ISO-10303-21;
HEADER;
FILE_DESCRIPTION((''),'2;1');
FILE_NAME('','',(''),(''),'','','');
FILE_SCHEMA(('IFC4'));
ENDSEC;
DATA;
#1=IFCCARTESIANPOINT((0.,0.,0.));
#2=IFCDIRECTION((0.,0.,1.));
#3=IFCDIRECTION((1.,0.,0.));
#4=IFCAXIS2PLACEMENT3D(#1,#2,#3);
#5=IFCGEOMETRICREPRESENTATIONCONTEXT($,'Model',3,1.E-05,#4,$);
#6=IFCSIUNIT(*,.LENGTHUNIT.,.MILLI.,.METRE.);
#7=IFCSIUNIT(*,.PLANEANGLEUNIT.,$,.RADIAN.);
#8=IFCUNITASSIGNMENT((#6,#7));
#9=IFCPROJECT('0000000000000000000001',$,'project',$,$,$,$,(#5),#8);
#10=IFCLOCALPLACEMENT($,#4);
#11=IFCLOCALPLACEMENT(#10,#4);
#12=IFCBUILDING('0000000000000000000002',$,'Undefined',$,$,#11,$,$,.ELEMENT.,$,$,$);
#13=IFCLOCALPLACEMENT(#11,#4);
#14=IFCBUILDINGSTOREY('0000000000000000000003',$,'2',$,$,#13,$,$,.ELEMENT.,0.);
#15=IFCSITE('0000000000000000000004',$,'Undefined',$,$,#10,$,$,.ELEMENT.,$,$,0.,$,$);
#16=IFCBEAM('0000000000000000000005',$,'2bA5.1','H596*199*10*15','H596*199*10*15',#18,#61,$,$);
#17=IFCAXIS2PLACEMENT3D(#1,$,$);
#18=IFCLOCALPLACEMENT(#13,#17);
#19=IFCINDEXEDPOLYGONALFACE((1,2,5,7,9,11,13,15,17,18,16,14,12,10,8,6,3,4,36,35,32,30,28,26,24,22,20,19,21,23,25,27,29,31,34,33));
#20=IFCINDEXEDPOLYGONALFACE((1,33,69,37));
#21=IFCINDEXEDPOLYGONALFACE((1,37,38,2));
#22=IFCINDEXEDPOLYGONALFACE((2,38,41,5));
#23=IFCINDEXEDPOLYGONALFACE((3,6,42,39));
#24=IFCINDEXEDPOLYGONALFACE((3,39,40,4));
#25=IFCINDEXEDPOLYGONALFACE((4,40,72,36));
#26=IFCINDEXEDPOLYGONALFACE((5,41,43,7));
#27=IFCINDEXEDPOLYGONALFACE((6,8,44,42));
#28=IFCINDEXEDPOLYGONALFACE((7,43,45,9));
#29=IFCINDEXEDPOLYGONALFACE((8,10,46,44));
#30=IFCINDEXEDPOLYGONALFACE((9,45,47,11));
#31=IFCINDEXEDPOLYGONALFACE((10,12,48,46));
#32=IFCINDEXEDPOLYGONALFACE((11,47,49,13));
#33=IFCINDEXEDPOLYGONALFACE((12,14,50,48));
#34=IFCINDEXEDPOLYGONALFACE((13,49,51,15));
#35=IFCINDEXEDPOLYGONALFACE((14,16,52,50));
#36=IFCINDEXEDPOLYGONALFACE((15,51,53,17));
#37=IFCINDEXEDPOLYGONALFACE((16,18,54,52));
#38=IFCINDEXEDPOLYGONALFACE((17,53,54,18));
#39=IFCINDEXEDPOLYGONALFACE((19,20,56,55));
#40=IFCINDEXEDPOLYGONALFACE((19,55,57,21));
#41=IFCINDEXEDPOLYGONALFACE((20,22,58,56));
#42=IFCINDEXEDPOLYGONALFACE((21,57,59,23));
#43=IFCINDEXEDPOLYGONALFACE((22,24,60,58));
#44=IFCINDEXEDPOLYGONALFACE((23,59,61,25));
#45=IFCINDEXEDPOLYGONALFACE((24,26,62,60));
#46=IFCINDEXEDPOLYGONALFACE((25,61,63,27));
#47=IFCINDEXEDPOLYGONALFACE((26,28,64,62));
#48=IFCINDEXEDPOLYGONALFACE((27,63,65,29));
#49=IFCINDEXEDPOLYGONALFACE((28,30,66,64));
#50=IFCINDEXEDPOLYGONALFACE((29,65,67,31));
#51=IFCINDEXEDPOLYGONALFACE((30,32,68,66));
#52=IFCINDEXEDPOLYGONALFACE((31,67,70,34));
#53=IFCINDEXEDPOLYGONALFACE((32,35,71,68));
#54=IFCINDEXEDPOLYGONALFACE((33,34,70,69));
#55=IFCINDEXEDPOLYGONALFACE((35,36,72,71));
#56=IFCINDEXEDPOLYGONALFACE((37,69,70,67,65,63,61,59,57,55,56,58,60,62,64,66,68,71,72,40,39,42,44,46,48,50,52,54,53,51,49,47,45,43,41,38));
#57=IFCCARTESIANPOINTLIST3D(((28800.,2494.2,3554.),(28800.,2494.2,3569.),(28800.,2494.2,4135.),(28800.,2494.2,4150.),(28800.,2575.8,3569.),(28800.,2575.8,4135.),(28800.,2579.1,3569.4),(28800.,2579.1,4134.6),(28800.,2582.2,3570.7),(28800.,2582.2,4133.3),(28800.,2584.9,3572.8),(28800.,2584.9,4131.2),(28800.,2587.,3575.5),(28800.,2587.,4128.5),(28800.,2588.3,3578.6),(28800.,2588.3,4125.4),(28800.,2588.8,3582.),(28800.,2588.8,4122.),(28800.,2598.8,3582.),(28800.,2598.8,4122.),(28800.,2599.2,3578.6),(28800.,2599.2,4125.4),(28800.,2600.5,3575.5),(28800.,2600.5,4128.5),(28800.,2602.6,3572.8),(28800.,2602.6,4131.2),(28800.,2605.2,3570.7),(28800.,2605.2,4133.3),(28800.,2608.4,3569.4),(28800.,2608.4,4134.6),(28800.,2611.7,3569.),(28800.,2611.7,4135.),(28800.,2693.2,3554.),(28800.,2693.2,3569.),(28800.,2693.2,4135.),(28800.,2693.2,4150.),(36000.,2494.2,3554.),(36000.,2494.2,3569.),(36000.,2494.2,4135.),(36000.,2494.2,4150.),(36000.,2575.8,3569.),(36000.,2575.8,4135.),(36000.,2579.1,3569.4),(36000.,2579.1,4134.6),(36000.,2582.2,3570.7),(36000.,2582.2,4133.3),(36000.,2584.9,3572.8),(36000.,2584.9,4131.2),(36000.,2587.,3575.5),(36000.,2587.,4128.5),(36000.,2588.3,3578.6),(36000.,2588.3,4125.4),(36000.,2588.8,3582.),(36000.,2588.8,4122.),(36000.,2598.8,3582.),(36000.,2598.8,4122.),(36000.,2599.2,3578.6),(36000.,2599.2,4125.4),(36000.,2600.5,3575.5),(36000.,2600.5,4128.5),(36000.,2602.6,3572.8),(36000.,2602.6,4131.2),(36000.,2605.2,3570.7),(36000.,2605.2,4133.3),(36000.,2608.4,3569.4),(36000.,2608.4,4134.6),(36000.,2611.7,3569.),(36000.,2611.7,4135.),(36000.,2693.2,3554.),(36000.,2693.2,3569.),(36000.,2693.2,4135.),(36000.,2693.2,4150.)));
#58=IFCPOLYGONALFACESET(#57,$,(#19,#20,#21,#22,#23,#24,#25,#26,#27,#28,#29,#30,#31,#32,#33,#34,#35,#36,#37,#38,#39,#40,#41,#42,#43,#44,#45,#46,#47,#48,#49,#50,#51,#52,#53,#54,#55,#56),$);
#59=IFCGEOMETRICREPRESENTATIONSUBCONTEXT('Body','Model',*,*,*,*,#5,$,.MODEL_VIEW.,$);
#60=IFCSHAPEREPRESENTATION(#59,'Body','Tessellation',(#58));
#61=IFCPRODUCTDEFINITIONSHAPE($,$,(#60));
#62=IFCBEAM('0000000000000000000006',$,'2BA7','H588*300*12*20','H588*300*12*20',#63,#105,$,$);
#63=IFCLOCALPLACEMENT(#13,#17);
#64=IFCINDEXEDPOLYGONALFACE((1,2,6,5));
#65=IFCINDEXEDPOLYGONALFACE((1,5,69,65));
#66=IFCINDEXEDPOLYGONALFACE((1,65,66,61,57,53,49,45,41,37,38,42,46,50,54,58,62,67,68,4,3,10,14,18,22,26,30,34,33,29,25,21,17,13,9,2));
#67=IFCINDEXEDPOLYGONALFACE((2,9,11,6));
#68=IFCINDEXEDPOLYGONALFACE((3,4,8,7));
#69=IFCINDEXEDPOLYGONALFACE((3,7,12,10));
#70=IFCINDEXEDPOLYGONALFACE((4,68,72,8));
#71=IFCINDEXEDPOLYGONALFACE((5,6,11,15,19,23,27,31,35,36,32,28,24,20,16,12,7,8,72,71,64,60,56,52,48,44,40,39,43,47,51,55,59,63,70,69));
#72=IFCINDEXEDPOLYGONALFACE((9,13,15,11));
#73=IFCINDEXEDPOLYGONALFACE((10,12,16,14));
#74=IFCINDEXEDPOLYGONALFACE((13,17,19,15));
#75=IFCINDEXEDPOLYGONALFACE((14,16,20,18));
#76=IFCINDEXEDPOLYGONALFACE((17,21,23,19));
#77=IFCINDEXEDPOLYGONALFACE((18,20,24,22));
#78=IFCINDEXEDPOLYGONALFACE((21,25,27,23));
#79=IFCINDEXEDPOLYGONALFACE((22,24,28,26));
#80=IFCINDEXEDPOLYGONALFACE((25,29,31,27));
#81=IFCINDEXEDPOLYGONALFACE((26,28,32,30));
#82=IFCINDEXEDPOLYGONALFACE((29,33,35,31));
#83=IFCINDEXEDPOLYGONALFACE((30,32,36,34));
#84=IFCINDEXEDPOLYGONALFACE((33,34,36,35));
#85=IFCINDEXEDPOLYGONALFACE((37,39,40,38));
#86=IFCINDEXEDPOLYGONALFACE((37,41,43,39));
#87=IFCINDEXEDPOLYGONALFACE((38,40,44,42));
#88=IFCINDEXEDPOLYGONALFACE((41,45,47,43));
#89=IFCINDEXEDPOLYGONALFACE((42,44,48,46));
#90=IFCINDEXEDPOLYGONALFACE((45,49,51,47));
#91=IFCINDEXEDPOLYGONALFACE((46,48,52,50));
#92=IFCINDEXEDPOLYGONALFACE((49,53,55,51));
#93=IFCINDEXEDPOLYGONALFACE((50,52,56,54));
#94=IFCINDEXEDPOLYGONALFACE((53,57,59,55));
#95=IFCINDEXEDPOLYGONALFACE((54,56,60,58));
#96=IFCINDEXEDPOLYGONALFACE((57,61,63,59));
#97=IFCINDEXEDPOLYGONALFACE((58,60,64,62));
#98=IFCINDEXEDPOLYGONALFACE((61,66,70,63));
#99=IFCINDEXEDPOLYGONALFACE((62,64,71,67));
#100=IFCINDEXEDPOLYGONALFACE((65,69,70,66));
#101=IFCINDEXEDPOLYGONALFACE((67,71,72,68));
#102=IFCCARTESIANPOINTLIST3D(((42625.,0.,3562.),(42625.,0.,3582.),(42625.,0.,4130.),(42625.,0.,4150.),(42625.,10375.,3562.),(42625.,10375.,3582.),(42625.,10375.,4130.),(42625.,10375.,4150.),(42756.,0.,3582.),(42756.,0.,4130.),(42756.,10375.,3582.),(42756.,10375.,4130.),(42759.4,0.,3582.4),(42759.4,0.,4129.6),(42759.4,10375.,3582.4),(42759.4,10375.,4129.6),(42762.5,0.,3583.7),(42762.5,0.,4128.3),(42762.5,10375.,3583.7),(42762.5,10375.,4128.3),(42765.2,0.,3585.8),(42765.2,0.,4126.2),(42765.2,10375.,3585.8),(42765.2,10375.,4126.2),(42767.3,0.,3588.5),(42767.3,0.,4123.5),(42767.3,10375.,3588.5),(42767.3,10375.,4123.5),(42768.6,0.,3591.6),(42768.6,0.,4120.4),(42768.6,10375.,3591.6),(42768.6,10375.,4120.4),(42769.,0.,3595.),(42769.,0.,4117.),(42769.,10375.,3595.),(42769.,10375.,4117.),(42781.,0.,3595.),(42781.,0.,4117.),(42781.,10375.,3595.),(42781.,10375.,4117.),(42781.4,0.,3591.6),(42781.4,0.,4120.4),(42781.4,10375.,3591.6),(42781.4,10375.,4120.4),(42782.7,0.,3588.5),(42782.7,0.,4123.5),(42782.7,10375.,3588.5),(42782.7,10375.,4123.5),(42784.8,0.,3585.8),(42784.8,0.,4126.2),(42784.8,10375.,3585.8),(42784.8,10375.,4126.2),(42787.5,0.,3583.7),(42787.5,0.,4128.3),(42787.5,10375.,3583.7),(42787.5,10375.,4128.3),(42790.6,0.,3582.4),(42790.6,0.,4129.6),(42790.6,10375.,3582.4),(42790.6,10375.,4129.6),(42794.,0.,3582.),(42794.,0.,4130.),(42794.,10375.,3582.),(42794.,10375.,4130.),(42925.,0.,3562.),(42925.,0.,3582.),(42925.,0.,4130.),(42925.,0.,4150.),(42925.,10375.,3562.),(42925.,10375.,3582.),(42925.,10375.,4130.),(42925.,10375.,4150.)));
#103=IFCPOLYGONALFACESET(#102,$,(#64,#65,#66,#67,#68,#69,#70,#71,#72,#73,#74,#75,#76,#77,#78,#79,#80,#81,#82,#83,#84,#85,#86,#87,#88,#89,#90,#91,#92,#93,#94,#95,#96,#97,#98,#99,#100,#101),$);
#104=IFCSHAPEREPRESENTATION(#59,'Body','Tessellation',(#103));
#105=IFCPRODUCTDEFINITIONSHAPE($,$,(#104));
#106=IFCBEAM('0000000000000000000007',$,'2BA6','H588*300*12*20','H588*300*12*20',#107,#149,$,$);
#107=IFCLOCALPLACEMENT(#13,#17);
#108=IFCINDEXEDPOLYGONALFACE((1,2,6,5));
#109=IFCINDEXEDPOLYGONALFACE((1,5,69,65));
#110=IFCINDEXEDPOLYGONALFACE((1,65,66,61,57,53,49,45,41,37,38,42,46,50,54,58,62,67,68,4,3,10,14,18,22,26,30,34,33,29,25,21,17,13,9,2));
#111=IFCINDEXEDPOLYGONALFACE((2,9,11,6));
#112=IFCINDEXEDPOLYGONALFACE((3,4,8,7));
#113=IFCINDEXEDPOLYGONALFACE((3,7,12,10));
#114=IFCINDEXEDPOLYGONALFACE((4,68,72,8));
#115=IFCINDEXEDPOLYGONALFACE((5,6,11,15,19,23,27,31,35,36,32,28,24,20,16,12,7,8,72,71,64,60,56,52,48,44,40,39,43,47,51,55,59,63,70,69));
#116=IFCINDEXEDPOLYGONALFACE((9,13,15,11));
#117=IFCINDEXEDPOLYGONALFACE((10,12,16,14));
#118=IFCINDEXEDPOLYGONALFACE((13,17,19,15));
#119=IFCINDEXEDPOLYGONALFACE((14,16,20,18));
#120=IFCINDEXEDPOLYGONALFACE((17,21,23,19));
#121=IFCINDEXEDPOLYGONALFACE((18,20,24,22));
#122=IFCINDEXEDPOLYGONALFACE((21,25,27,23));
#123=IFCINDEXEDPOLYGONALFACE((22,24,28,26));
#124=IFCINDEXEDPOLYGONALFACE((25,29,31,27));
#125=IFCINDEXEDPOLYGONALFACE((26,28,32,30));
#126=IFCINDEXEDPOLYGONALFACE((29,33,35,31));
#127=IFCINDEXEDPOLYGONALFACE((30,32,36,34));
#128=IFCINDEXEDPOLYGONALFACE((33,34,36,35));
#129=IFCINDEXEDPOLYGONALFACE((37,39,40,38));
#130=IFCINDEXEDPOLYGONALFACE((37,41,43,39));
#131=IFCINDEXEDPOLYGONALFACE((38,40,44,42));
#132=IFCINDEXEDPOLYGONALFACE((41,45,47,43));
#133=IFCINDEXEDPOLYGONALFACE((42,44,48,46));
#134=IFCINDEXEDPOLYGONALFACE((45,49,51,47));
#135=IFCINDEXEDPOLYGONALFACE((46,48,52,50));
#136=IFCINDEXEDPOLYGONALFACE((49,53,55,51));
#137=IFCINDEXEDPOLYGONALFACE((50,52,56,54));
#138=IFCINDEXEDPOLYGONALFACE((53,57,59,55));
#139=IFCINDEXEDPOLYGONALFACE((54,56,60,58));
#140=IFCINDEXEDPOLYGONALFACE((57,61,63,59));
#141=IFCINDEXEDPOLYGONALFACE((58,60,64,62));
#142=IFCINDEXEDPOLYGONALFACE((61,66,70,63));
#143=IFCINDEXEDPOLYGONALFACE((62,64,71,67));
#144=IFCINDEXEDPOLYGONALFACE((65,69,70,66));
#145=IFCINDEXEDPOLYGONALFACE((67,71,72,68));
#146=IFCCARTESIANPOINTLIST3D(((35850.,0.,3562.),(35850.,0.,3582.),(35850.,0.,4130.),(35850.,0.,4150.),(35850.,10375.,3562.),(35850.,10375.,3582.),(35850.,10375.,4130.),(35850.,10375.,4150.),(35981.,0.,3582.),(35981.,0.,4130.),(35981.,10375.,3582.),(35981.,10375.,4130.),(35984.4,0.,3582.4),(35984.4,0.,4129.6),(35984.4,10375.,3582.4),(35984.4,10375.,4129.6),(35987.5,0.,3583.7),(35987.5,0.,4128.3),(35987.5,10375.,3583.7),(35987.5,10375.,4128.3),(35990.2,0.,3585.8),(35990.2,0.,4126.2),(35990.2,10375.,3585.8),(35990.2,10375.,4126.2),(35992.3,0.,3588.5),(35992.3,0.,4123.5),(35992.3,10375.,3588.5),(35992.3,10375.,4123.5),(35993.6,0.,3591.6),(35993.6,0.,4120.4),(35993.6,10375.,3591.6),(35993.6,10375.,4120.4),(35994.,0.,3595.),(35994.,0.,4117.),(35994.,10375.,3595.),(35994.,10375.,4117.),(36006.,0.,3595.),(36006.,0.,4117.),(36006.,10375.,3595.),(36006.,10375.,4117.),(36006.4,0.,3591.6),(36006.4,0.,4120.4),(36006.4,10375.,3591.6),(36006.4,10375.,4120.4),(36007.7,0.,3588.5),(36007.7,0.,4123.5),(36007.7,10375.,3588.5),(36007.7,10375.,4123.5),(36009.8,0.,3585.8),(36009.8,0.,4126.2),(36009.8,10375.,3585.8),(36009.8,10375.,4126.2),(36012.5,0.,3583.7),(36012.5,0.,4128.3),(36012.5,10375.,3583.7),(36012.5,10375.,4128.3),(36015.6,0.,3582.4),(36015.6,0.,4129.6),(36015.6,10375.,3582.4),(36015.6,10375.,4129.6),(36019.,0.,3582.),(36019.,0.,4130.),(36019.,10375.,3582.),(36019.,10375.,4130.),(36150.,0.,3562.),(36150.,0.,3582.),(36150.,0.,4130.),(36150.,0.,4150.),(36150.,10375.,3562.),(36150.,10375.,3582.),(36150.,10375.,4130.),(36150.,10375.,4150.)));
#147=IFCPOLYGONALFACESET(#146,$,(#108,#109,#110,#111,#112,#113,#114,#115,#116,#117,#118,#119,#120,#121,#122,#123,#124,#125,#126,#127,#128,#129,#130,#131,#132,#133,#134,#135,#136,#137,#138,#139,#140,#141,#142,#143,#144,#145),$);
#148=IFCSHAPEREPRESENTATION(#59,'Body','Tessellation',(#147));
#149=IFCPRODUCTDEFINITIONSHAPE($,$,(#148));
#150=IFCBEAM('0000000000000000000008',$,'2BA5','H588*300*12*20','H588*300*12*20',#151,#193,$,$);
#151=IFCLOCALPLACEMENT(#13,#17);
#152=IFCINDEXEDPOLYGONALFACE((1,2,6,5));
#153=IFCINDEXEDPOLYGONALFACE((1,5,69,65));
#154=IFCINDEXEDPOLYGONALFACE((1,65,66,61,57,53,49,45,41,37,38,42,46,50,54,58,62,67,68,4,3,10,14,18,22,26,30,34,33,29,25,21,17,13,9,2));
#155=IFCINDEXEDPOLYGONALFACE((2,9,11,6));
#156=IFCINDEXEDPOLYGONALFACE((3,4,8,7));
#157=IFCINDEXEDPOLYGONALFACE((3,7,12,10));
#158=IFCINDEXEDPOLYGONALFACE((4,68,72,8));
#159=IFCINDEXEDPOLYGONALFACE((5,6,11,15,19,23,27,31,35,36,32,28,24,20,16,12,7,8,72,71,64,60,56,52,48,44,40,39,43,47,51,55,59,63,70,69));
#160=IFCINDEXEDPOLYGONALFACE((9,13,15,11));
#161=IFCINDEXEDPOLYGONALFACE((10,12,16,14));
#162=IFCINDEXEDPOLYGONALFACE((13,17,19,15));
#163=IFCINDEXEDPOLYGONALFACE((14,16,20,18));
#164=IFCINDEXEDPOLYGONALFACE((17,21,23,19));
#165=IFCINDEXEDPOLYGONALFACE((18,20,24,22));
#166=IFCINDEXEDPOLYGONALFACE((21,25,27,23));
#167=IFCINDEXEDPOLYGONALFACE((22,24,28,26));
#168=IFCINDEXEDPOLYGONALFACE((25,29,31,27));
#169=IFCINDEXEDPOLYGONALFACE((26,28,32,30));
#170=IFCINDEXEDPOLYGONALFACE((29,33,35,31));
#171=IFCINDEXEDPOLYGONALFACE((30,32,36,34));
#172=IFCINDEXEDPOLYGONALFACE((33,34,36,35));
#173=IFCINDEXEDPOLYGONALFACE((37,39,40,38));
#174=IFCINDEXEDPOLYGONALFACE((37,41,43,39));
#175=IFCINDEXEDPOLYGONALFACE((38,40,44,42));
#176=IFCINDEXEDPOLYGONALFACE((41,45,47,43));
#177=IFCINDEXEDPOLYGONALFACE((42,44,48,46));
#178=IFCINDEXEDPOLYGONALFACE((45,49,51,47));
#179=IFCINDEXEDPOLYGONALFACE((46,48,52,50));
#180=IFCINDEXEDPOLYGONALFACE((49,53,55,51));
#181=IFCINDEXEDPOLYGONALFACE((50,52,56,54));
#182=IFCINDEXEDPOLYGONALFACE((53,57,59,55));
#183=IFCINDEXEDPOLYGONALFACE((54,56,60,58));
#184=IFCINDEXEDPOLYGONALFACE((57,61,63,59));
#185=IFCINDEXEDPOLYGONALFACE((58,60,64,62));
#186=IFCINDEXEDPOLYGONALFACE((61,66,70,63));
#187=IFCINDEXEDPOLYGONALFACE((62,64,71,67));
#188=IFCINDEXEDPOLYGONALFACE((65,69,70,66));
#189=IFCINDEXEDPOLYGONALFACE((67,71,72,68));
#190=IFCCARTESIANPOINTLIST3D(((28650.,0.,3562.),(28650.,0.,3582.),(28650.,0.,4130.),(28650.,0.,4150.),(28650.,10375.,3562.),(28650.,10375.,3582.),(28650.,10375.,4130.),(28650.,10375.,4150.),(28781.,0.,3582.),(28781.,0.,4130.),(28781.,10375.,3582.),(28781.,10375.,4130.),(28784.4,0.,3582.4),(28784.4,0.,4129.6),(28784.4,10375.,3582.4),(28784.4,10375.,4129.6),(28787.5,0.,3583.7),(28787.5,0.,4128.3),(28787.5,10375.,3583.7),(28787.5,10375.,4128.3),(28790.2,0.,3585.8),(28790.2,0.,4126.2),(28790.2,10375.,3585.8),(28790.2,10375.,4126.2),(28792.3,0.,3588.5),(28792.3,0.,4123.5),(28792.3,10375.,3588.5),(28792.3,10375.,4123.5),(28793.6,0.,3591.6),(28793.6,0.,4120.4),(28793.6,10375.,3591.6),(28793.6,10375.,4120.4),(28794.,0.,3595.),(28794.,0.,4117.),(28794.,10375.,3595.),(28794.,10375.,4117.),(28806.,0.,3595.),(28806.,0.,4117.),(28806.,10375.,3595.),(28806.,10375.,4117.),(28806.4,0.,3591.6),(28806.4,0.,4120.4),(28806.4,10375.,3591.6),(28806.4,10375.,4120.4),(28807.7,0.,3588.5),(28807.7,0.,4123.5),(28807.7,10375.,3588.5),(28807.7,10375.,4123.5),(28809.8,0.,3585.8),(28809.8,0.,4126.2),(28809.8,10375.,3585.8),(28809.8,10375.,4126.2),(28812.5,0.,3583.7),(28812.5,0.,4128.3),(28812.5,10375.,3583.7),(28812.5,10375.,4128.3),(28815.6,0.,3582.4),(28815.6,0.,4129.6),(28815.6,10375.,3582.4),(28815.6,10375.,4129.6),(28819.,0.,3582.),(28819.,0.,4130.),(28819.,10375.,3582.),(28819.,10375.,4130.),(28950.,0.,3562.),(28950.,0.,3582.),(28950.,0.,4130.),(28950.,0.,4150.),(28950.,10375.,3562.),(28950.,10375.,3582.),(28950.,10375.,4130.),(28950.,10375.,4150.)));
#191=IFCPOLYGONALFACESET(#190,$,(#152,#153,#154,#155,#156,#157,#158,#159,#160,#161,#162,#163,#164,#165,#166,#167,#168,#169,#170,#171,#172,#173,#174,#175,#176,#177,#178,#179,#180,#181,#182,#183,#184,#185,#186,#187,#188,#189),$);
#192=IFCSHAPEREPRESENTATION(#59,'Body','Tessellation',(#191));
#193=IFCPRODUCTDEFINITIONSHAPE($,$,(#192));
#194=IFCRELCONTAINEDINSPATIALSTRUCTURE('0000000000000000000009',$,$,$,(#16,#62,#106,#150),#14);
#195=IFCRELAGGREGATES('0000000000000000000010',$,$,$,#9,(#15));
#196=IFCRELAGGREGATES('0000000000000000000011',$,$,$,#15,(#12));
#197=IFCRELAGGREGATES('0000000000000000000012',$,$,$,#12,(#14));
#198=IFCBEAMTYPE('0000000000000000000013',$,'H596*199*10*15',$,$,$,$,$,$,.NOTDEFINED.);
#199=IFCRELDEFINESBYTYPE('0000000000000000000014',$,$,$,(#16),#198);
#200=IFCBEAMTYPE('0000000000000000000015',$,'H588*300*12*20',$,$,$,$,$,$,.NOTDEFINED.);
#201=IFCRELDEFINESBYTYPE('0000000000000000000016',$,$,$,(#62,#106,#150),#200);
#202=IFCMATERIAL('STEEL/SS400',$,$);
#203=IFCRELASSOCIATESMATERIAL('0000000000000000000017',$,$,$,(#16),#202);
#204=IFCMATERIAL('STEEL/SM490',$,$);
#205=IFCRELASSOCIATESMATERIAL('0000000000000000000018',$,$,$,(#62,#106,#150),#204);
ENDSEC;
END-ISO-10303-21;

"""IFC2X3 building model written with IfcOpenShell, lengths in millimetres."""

from ifc_helpers import new_model, si_unit, frame, origin_with_axes, origin_2d_with_axis, place, context, subcontext, project, spatial, i_section, extrude, material, type_object, element, save


model = new_model("IFC2X3")

# Units and contexts
model_context = context("Model", 3, precision=1e-05, world=origin_with_axes())
body_context = subcontext(model_context, "Body", "Model", "MODEL_VIEW")
ifc_project = project(units=[si_unit("LENGTHUNIT", "METRE", prefix="MILLI"), si_unit("PLANEANGLEUNIT", "RADIAN")], contexts=[model_context])

# Site, building, storey
site_placement = place(None, origin_with_axes())
site = spatial("IfcSite", under=ifc_project, at=site_placement, Name="Undefined", CompositionType="ELEMENT", RefElevation=0.0)
building_placement = place(site_placement, origin_with_axes())
building = spatial("IfcBuilding", under=site, at=building_placement, Name="Undefined", CompositionType="ELEMENT")
storey_placement = place(building_placement, origin_with_axes())
storey = spatial("IfcBuildingStorey", under=building, at=storey_placement, Name="2", CompositionType="ELEMENT", Elevation=0.0)

# Beams
ifc_material_1 = material(Name="STEEL/SS400")
beam_type_1 = type_object("IfcBeamType", Name="H596*199*10*15", PredefinedType="NOTDEFINED")
for number, where, z_axis, x_axis, name in (
    (1, (28800.0, 2593.8, 3852.0), (0.0, 0.0, 1.0), (1.0, 0.0, 0.0), "2bA5.1"),
):
    element("IfcBeam", number, at=place(storey_placement, frame(where, z_axis=z_axis, x_axis=x_axis)), inside=storey, type_object=beam_type_1, material=ifc_material_1, Name=name, Description="H596*199*10*15", ObjectType="H596*199*10*15", context=body_context, shape_type="SweptSolid", body=[
        extrude(i_section(OverallWidth=199.0, OverallDepth=596.0, WebThickness=10.0, FlangeThickness=15.0, FilletRadius=13.0, at=origin_2d_with_axis()), frame((7200.0, 0.0, 0.0), z_axis=(-1.0, 0.0, 0.0), x_axis=(0.0, -1.0, 0.0)), (0.0, 0.0, 1.0), 7200.0),
    ])
ifc_material_2 = material(Name="STEEL/SM490")
beam_type_2 = type_object("IfcBeamType", Name="H588*300*12*20", PredefinedType="NOTDEFINED")
for number, where, z_axis, x_axis, name in (
    (2, (42775.0, 0.0, 3856.0), (0.0, 0.0, 1.0), (0.0, 1.0, 0.0), "2BA7"),
    (3, (36000.0, 0.0, 3856.0), (0.0, 0.0, 1.0), (0.0, 1.0, 0.0), "2BA6"),
    (4, (28800.0, 0.0, 3856.0), (0.0, 0.0, 1.0), (0.0, 1.0, 0.0), "2BA5"),
):
    element("IfcBeam", number, at=place(storey_placement, frame(where, z_axis=z_axis, x_axis=x_axis)), inside=storey, type_object=beam_type_2, material=ifc_material_2, Name=name, Description="H588*300*12*20", ObjectType="H588*300*12*20", context=body_context, shape_type="SweptSolid", body=[
        extrude(i_section(OverallWidth=300.0, OverallDepth=588.0, WebThickness=12.0, FlangeThickness=20.0, FilletRadius=13.0, at=origin_2d_with_axis()), frame((10375.0, 0.0, 0.0), z_axis=(-1.0, 0.0, 0.0), x_axis=(0.0, -1.0, 0.0)), (0.0, 0.0, 1.0), 10375.0),
    ])

save(model, "model.ifc")
